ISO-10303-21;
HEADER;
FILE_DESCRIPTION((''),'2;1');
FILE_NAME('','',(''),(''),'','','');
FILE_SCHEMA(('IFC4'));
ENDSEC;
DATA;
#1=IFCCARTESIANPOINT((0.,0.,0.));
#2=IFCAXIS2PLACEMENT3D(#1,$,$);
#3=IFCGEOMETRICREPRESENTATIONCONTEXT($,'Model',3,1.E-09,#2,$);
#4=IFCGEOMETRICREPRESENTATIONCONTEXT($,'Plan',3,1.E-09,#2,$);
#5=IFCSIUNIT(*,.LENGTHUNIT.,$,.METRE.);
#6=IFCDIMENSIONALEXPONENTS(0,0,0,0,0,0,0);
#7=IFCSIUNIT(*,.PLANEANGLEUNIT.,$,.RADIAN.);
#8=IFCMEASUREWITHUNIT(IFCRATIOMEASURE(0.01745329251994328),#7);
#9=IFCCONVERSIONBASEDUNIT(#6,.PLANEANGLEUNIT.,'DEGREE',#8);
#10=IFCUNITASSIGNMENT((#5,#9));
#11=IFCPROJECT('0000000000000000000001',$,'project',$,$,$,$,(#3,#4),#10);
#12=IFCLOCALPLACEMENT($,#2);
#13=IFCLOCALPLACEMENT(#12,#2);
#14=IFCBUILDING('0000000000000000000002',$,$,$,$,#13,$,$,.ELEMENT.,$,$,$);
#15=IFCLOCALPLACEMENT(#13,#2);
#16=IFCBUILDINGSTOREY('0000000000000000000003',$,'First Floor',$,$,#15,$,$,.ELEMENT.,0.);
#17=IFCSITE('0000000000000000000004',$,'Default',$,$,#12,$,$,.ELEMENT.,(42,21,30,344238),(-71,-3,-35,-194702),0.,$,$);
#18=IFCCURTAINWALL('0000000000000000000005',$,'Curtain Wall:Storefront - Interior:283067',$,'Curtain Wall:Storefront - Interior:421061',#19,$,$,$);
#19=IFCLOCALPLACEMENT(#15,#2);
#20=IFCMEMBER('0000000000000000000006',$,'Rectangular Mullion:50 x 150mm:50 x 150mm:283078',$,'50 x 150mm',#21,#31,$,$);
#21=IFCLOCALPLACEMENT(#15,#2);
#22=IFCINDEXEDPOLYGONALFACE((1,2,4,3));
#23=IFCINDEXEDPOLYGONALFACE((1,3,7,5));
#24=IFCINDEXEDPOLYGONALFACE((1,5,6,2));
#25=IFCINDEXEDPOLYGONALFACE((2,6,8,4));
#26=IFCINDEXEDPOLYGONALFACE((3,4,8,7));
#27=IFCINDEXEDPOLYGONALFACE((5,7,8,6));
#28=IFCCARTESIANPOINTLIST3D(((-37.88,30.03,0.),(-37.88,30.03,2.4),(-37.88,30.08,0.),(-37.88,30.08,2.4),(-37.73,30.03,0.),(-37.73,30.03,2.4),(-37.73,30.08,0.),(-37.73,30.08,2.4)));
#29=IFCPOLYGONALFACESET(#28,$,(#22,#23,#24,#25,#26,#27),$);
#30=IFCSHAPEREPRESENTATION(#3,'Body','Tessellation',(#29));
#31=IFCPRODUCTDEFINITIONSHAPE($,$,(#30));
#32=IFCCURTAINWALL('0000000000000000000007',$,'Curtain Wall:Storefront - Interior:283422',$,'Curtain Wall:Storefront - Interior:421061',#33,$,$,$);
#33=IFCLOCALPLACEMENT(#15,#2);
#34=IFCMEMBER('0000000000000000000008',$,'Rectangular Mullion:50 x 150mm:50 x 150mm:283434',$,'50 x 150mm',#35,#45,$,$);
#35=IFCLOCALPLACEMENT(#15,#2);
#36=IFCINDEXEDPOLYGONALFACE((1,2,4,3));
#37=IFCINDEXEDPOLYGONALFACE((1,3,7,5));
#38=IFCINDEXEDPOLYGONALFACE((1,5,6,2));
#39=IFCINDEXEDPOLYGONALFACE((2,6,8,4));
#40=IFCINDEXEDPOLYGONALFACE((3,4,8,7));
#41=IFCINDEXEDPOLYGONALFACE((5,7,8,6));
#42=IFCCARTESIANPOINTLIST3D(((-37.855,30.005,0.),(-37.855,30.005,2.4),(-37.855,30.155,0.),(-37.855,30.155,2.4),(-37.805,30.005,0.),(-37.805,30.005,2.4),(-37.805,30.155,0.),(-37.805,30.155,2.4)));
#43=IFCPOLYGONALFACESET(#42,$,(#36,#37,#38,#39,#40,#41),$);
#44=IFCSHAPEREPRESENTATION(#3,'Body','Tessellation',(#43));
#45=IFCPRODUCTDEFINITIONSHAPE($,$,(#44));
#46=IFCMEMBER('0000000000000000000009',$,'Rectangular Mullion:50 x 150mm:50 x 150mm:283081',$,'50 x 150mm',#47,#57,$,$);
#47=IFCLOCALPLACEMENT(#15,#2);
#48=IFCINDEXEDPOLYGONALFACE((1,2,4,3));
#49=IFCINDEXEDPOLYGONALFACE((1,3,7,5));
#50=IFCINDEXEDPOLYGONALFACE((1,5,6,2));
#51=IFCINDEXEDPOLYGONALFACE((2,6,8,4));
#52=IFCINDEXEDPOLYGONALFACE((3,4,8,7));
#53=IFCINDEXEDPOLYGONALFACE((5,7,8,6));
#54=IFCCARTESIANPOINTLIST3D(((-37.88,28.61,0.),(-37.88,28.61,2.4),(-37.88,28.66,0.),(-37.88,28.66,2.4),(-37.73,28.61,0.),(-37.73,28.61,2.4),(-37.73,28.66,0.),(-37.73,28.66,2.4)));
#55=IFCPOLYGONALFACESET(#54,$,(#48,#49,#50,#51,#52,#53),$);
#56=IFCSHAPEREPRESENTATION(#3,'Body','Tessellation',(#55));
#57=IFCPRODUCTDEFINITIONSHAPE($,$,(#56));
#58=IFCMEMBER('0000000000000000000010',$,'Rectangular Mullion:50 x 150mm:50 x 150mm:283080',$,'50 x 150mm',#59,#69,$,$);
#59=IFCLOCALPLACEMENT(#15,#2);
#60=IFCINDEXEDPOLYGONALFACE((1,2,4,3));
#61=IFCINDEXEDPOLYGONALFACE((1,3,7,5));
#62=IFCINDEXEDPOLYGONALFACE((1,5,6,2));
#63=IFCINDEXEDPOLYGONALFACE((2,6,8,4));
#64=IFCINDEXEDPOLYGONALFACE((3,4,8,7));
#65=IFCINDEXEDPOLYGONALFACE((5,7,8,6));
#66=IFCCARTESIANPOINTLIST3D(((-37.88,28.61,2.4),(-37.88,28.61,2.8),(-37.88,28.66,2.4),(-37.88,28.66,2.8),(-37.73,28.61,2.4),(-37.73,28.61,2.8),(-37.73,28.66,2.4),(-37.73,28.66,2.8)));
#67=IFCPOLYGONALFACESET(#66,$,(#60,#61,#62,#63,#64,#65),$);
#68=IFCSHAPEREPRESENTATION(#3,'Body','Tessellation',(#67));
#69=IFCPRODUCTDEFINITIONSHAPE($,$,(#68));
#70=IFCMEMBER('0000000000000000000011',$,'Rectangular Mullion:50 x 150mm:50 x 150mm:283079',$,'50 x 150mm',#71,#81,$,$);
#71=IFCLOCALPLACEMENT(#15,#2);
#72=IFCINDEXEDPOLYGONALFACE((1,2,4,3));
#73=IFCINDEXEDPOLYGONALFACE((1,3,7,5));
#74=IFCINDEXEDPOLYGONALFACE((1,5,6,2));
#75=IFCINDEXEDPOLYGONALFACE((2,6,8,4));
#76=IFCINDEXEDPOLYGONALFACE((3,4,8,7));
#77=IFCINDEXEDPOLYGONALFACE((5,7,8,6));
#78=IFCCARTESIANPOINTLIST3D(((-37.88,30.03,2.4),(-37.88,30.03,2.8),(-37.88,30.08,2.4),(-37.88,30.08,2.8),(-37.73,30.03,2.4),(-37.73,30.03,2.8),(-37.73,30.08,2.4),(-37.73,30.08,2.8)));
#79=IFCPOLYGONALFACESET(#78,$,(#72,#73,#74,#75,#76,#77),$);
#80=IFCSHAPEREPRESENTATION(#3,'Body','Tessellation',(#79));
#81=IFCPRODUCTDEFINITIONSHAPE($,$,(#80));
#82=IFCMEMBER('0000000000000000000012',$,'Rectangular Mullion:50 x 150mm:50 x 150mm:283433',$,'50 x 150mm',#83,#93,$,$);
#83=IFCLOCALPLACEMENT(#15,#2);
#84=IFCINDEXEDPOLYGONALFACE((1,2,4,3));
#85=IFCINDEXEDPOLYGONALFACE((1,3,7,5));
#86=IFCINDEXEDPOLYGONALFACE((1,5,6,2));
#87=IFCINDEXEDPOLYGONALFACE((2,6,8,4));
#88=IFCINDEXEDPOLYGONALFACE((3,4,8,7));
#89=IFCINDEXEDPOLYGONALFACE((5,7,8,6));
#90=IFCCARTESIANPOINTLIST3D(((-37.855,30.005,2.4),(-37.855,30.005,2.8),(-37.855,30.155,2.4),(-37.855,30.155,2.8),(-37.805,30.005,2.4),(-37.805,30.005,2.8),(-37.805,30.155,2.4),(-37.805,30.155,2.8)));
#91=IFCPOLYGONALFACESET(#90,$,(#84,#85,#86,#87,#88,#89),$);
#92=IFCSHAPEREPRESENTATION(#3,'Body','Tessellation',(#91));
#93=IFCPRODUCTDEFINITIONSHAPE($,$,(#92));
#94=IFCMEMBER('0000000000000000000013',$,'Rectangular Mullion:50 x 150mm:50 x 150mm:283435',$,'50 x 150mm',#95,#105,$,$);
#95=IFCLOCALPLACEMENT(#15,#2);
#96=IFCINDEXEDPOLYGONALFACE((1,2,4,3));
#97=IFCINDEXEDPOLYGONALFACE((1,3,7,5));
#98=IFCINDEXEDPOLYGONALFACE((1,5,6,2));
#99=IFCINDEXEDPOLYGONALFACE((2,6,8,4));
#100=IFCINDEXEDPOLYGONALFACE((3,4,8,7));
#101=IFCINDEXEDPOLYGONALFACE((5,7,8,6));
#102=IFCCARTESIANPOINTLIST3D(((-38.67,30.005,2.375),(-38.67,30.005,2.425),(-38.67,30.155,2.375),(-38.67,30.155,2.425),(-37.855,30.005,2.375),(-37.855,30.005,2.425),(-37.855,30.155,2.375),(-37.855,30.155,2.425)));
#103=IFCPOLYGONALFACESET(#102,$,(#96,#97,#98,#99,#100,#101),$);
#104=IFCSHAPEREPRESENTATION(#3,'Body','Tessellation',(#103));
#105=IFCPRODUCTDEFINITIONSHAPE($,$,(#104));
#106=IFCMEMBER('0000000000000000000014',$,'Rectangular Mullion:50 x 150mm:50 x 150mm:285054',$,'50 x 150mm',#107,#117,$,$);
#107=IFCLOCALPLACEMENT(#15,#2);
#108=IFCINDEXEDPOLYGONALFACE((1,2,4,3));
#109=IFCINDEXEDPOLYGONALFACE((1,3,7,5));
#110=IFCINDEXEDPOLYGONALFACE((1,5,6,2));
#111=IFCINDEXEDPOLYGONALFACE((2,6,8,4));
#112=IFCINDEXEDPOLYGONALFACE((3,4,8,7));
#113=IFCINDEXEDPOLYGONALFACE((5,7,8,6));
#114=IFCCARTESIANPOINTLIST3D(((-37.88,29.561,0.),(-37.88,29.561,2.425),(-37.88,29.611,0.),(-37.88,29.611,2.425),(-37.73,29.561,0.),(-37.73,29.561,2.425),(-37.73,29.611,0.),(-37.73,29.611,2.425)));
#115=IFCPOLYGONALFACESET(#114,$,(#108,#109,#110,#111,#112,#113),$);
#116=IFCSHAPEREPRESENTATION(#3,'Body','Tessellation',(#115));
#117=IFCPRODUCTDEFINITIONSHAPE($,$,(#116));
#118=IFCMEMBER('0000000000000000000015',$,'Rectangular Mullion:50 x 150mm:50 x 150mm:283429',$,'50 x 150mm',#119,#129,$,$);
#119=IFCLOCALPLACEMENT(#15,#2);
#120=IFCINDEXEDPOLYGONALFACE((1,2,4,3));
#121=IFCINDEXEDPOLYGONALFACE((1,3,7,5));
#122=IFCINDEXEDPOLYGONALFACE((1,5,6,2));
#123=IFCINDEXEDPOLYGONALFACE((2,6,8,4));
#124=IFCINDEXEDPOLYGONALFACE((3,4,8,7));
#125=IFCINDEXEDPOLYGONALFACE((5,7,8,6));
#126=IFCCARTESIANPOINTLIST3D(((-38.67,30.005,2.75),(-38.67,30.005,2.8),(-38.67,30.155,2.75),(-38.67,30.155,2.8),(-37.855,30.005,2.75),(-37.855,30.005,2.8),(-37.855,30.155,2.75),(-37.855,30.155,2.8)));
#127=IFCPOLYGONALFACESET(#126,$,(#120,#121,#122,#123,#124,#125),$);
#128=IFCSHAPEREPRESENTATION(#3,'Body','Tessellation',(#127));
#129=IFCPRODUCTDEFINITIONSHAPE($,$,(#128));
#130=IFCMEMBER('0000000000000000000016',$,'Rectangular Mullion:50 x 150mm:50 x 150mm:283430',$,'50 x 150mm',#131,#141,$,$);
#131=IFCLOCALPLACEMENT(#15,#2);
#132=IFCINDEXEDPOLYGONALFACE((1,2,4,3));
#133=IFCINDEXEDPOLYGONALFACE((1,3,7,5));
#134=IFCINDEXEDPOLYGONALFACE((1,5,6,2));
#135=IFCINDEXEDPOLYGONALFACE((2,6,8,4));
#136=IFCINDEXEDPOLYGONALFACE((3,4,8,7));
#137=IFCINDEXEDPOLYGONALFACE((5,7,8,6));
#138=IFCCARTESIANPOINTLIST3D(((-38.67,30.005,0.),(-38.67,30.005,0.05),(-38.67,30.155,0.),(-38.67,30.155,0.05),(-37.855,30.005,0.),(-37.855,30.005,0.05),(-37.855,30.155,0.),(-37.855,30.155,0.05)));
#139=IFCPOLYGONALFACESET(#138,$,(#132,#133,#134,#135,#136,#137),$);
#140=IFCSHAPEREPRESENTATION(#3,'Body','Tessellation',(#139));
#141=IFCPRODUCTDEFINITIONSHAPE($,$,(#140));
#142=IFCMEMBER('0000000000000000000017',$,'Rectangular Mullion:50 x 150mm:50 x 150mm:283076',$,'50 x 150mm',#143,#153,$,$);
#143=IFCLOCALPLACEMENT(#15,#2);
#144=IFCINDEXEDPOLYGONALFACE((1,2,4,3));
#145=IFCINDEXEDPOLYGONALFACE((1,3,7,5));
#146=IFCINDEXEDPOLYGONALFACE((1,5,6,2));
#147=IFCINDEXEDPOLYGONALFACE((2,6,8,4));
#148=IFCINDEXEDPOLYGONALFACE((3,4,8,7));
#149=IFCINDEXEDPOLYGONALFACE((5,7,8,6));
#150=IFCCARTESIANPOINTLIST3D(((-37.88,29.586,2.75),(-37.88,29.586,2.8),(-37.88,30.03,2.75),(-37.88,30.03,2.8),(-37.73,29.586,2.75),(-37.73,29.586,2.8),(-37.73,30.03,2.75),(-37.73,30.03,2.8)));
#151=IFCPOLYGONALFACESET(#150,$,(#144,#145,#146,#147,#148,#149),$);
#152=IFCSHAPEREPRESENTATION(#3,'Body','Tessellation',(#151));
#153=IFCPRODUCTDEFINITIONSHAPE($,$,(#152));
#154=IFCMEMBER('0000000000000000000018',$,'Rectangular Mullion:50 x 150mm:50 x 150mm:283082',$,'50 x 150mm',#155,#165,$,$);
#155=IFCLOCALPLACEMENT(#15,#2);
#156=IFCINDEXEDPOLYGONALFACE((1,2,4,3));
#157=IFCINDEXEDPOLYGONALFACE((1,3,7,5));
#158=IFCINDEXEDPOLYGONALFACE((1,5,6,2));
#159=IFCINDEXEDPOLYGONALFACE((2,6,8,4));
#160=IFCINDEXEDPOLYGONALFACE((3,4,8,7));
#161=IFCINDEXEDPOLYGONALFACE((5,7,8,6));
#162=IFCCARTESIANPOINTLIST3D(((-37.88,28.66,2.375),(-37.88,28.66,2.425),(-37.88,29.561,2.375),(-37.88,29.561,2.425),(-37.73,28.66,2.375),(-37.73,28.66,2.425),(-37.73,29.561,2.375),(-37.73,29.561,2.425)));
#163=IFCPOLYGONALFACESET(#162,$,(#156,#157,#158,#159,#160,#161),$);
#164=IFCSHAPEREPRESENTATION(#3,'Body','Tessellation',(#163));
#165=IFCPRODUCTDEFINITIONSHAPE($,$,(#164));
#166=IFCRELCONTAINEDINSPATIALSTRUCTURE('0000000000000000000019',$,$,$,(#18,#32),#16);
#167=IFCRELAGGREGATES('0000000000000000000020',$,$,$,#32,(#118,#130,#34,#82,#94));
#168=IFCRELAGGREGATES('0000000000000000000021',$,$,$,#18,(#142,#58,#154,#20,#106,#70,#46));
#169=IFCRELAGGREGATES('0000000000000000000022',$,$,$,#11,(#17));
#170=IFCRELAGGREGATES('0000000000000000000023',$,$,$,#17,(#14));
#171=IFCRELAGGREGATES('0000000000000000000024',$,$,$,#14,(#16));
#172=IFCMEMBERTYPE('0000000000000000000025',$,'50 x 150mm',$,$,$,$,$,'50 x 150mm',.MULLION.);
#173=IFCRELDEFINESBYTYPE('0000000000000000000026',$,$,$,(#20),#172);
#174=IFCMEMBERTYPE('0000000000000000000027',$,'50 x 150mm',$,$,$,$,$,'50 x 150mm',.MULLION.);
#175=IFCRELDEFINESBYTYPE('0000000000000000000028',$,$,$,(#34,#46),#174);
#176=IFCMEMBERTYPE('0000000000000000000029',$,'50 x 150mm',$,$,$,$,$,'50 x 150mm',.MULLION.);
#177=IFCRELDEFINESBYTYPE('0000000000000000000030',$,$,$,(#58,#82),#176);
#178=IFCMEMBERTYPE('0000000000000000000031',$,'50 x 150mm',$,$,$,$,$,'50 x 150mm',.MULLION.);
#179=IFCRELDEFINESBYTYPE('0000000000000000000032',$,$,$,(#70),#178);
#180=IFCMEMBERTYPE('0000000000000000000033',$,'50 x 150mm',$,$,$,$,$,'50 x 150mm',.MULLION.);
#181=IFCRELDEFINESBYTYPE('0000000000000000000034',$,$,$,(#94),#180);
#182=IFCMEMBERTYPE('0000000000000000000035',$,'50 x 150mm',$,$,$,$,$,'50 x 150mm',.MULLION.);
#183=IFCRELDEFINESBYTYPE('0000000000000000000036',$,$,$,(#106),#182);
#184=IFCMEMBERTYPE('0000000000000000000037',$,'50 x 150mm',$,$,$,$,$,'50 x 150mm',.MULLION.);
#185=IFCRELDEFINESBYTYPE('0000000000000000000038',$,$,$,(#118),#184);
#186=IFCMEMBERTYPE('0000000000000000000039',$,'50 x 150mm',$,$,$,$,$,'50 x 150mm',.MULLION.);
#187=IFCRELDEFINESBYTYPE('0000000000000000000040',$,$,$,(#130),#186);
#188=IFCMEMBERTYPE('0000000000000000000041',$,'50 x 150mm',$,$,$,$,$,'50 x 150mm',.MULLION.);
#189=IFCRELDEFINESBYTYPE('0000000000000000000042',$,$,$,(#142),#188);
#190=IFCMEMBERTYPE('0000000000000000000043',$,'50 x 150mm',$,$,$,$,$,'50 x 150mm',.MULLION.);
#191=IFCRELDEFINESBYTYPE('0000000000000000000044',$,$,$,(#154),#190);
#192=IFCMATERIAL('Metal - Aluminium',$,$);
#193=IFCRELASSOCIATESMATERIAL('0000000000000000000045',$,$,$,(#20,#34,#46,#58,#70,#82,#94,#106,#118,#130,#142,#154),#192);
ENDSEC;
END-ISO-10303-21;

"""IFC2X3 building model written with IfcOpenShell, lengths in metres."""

from ifc_helpers import new_model, entity, si_unit, converted_unit, frame, origin, origin_2d_with_axis, place, context, project, spatial, rectangle, extrude, source, transform, mapped, material, type_object, type_shapes, element, aggregate, save


model = new_model("IFC2X3")

# Units and contexts
model_context = context("Model", 3, precision=1e-09, world=origin())
plan_context = context("Plan", 3, precision=1e-09, world=origin())
ifc_project = project(units=[si_unit("LENGTHUNIT", "METRE"), converted_unit("PLANEANGLEUNIT", "DEGREE", entity("IfcRatioMeasure", 0.01745329251994328), si_unit("PLANEANGLEUNIT", "RADIAN"), dimensions=[0, 0, 0, 0, 0, 0, 0])], contexts=[model_context, plan_context])

# Site, building, storey
site_placement = place(None, origin())
site = spatial("IfcSite", under=ifc_project, at=site_placement, Name="Default", CompositionType="ELEMENT", RefLatitude=(42, 21, 30, 344238), RefLongitude=(-71, -3, -35, -194702), RefElevation=0.0)
building_placement = place(site_placement, origin())
building = spatial("IfcBuilding", under=site, at=building_placement, CompositionType="ELEMENT")
storey_placement = place(building_placement, origin())
storey = spatial("IfcBuildingStorey", under=building, at=storey_placement, Name="First Floor", CompositionType="ELEMENT", Elevation=0.0)

# Curtain walls, members
curtain_wall_1_placement = place(storey_placement, origin())
curtain_wall_1 = element("IfcCurtainWall", 1, at=curtain_wall_1_placement, inside=storey, Name="Curtain Wall:Storefront - Interior:283067", ObjectType="Curtain Wall:Storefront - Interior:421061")
ifc_material_1 = material(Name="Metal - Aluminium")
member_type_1 = type_object("IfcMemberType", Name="50 x 150mm", ElementType="50 x 150mm", PredefinedType="MULLION")
shared_shape_1 = source(origin(), model_context, "Body", "SweptSolid", [
    extrude(rectangle(XDim=0.05, YDim=0.15, at=origin_2d_with_axis()), frame((-0.025, 0.0, -2.4), z_axis=(0.0, 0.0, 1.0), x_axis=(-1.0, 0.0, 0.0)), (0.0, 0.0, 1.0), 2.4),
])
type_shapes(member_type_1, [shared_shape_1])
member_1_placement = place(storey_placement, frame((-37.805, 30.08, 0.0), z_axis=(0.0, 0.0, -1.0), x_axis=(0.0, 1.0, 0.0)))
member_1 = element("IfcMember", 2, at=member_1_placement, type_object=member_type_1, material=ifc_material_1, Name="Rectangular Mullion:50 x 150mm:50 x 150mm:283078", ObjectType="50 x 150mm", context=model_context, shape_type="MappedRepresentation", body=[
    mapped(shared_shape_1, transform((0.0, 0.0, 0.0), scale=1.0)),
])
curtain_wall_2_placement = place(storey_placement, origin())
curtain_wall_2 = element("IfcCurtainWall", 3, at=curtain_wall_2_placement, inside=storey, Name="Curtain Wall:Storefront - Interior:283422", ObjectType="Curtain Wall:Storefront - Interior:421061")
member_type_2 = type_object("IfcMemberType", Name="50 x 150mm", ElementType="50 x 150mm", PredefinedType="MULLION")
type_shapes(member_type_2, [shared_shape_1])
member_2_placement = place(storey_placement, frame((-37.805, 30.08, 2.4)))
member_2 = element("IfcMember", 4, at=member_2_placement, type_object=member_type_2, material=ifc_material_1, Name="Rectangular Mullion:50 x 150mm:50 x 150mm:283434", ObjectType="50 x 150mm", context=model_context, shape_type="MappedRepresentation", body=[
    mapped(shared_shape_1, transform((0.0, 0.0, 0.0), scale=1.0)),
])

# Members
member_3_placement = place(storey_placement, frame((-37.805, 28.61, 2.4), z_axis=(0.0, 0.0, 1.0), x_axis=(0.0, -1.0, 0.0)))
member_3 = element("IfcMember", 5, at=member_3_placement, type_object=member_type_2, material=ifc_material_1, Name="Rectangular Mullion:50 x 150mm:50 x 150mm:283081", ObjectType="50 x 150mm", context=model_context, shape_type="MappedRepresentation", body=[
    mapped(shared_shape_1, transform((0.0, 0.0, 0.0), scale=1.0)),
])
member_type_3 = type_object("IfcMemberType", Name="50 x 150mm", ElementType="50 x 150mm", PredefinedType="MULLION")
shared_shape_2 = source(origin(), model_context, "Body", "SweptSolid", [
    extrude(rectangle(XDim=0.05, YDim=0.15, at=origin_2d_with_axis()), frame((-0.025, 0.0, -0.4), z_axis=(0.0, 0.0, 1.0), x_axis=(-1.0, 0.0, 0.0)), (0.0, 0.0, 1.0), 0.4),
])
type_shapes(member_type_3, [shared_shape_2])
member_4_placement = place(storey_placement, frame((-37.805, 28.61, 2.8), z_axis=(0.0, 0.0, 1.0), x_axis=(0.0, -1.0, 0.0)))
member_4 = element("IfcMember", 6, at=member_4_placement, type_object=member_type_3, material=ifc_material_1, Name="Rectangular Mullion:50 x 150mm:50 x 150mm:283080", ObjectType="50 x 150mm", context=model_context, shape_type="MappedRepresentation", body=[
    mapped(shared_shape_2, transform((0.0, 0.0, 0.0), scale=1.0)),
])
member_type_4 = type_object("IfcMemberType", Name="50 x 150mm", ElementType="50 x 150mm", PredefinedType="MULLION")
type_shapes(member_type_4, [shared_shape_2])
member_5_placement = place(storey_placement, frame((-37.805, 30.08, 2.4), z_axis=(0.0, 0.0, -1.0), x_axis=(0.0, 1.0, 0.0)))
member_5 = element("IfcMember", 7, at=member_5_placement, type_object=member_type_4, material=ifc_material_1, Name="Rectangular Mullion:50 x 150mm:50 x 150mm:283079", ObjectType="50 x 150mm", context=model_context, shape_type="MappedRepresentation", body=[
    mapped(shared_shape_2, transform((0.0, 0.0, 0.0), scale=1.0)),
])
member_6_placement = place(storey_placement, frame((-37.805, 30.08, 2.8)))
member_6 = element("IfcMember", 8, at=member_6_placement, type_object=member_type_3, material=ifc_material_1, Name="Rectangular Mullion:50 x 150mm:50 x 150mm:283433", ObjectType="50 x 150mm", context=model_context, shape_type="MappedRepresentation", body=[
    mapped(shared_shape_2, transform((0.0, 0.0, 0.0), scale=1.0)),
])
member_type_5 = type_object("IfcMemberType", Name="50 x 150mm", ElementType="50 x 150mm", PredefinedType="MULLION")
shared_shape_3 = source(origin(), model_context, "Body", "SweptSolid", [
    extrude(rectangle(XDim=0.05, YDim=0.15, at=origin_2d_with_axis()), frame((0.0, 0.0, -0.815), z_axis=(0.0, 0.0, 1.0), x_axis=(-1.0, 0.0, 0.0)), (0.0, 0.0, 1.0), 0.815),
])
type_shapes(member_type_5, [shared_shape_3])
member_7_placement = place(storey_placement, frame((-38.67, 30.08, 2.4), z_axis=(-1.0, 0.0, 0.0), x_axis=(0.0, 0.0, 1.0)))
member_7 = element("IfcMember", 9, at=member_7_placement, type_object=member_type_5, material=ifc_material_1, Name="Rectangular Mullion:50 x 150mm:50 x 150mm:283435", ObjectType="50 x 150mm", context=model_context, shape_type="MappedRepresentation", body=[
    mapped(shared_shape_3, transform((0.0, 0.0, 0.0), scale=1.0)),
])
member_type_6 = type_object("IfcMemberType", Name="50 x 150mm", ElementType="50 x 150mm", PredefinedType="MULLION")
shared_shape_4 = source(origin(), model_context, "Body", "SweptSolid", [
    extrude(rectangle(XDim=0.05, YDim=0.15, at=origin_2d_with_axis()), frame((0.0, 0.0, -2.425), z_axis=(0.0, 0.0, 1.0), x_axis=(-1.0, 0.0, 0.0)), (0.0, 0.0, 1.0), 2.425),
])
type_shapes(member_type_6, [shared_shape_4])
member_8_placement = place(storey_placement, frame((-37.805, 29.586, 0.0), z_axis=(0.0, 0.0, -1.0), x_axis=(0.0, 1.0, 0.0)))
member_8 = element("IfcMember", 10, at=member_8_placement, type_object=member_type_6, material=ifc_material_1, Name="Rectangular Mullion:50 x 150mm:50 x 150mm:285054", ObjectType="50 x 150mm", context=model_context, shape_type="MappedRepresentation", body=[
    mapped(shared_shape_4, transform((0.0, 0.0, 0.0), scale=1.0)),
])
member_type_7 = type_object("IfcMemberType", Name="50 x 150mm", ElementType="50 x 150mm", PredefinedType="MULLION")
shared_shape_5 = source(origin(), model_context, "Body", "SweptSolid", [
    extrude(rectangle(XDim=0.05, YDim=0.15, at=origin_2d_with_axis()), frame((-0.025, 0.0, -0.815), z_axis=(0.0, 0.0, 1.0), x_axis=(-1.0, 0.0, 0.0)), (0.0, 0.0, 1.0), 0.815),
])
type_shapes(member_type_7, [shared_shape_5])
member_9_placement = place(storey_placement, frame((-38.67, 30.08, 2.8), z_axis=(-1.0, 0.0, 0.0), x_axis=(0.0, 0.0, 1.0)))
member_9 = element("IfcMember", 11, at=member_9_placement, type_object=member_type_7, material=ifc_material_1, Name="Rectangular Mullion:50 x 150mm:50 x 150mm:283429", ObjectType="50 x 150mm", context=model_context, shape_type="MappedRepresentation", body=[
    mapped(shared_shape_5, transform((0.0, 0.0, 0.0), scale=1.0)),
])
member_type_8 = type_object("IfcMemberType", Name="50 x 150mm", ElementType="50 x 150mm", PredefinedType="MULLION")
shared_shape_6 = source(origin(), model_context, "Body", "SweptSolid", [
    extrude(rectangle(XDim=0.05, YDim=0.15, at=origin_2d_with_axis()), frame((-0.025, 0.0, -0.815), z_axis=(0.0, 0.0, 1.0), x_axis=(-1.0, 0.0, 0.0)), (0.0, 0.0, 1.0), 0.815),
])
type_shapes(member_type_8, [shared_shape_6])
member_10_placement = place(storey_placement, frame((-37.855, 30.08, 0.0), z_axis=(1.0, 0.0, 0.0), x_axis=(0.0, 0.0, -1.0)))
member_10 = element("IfcMember", 12, at=member_10_placement, type_object=member_type_8, material=ifc_material_1, Name="Rectangular Mullion:50 x 150mm:50 x 150mm:283430", ObjectType="50 x 150mm", context=model_context, shape_type="MappedRepresentation", body=[
    mapped(shared_shape_6, transform((0.0, 0.0, 0.0), scale=1.0)),
])
member_type_9 = type_object("IfcMemberType", Name="50 x 150mm", ElementType="50 x 150mm", PredefinedType="MULLION")
shared_shape_7 = source(origin(), model_context, "Body", "SweptSolid", [
    extrude(rectangle(XDim=0.05, YDim=0.15, at=origin_2d_with_axis()), frame((-0.025, 0.0, -0.444), z_axis=(0.0, 0.0, 1.0), x_axis=(-1.0, 0.0, 0.0)), (0.0, 0.0, 1.0), 0.444),
])
type_shapes(member_type_9, [shared_shape_7])
member_11_placement = place(storey_placement, frame((-37.805, 30.03, 2.8), z_axis=(0.0, 1.0, 0.0), x_axis=(0.0, 0.0, 1.0)))
member_11 = element("IfcMember", 13, at=member_11_placement, type_object=member_type_9, material=ifc_material_1, Name="Rectangular Mullion:50 x 150mm:50 x 150mm:283076", ObjectType="50 x 150mm", context=model_context, shape_type="MappedRepresentation", body=[
    mapped(shared_shape_7, transform((0.0, 0.0, 0.0), scale=1.0)),
])
member_type_10 = type_object("IfcMemberType", Name="50 x 150mm", ElementType="50 x 150mm", PredefinedType="MULLION")
shared_shape_8 = source(origin(), model_context, "Body", "SweptSolid", [
    extrude(rectangle(XDim=0.05, YDim=0.15, at=origin_2d_with_axis()), frame((0.0, 0.0, -0.901), z_axis=(0.0, 0.0, 1.0), x_axis=(-1.0, 0.0, 0.0)), (0.0, 0.0, 1.0), 0.901),
])
type_shapes(member_type_10, [shared_shape_8])
member_12_placement = place(storey_placement, frame((-37.805, 29.561, 2.4), z_axis=(0.0, 1.0, 0.0), x_axis=(0.0, 0.0, 1.0)))
member_12 = element("IfcMember", 14, at=member_12_placement, type_object=member_type_10, material=ifc_material_1, Name="Rectangular Mullion:50 x 150mm:50 x 150mm:283082", ObjectType="50 x 150mm", context=model_context, shape_type="MappedRepresentation", body=[
    mapped(shared_shape_8, transform((0.0, 0.0, 0.0), scale=1.0)),
])

aggregate(curtain_wall_2, [member_9, member_10, member_2, member_6, member_7])

aggregate(curtain_wall_1, [member_11, member_4, member_12, member_1, member_8, member_5, member_3])

save(model, "model.ifc")
